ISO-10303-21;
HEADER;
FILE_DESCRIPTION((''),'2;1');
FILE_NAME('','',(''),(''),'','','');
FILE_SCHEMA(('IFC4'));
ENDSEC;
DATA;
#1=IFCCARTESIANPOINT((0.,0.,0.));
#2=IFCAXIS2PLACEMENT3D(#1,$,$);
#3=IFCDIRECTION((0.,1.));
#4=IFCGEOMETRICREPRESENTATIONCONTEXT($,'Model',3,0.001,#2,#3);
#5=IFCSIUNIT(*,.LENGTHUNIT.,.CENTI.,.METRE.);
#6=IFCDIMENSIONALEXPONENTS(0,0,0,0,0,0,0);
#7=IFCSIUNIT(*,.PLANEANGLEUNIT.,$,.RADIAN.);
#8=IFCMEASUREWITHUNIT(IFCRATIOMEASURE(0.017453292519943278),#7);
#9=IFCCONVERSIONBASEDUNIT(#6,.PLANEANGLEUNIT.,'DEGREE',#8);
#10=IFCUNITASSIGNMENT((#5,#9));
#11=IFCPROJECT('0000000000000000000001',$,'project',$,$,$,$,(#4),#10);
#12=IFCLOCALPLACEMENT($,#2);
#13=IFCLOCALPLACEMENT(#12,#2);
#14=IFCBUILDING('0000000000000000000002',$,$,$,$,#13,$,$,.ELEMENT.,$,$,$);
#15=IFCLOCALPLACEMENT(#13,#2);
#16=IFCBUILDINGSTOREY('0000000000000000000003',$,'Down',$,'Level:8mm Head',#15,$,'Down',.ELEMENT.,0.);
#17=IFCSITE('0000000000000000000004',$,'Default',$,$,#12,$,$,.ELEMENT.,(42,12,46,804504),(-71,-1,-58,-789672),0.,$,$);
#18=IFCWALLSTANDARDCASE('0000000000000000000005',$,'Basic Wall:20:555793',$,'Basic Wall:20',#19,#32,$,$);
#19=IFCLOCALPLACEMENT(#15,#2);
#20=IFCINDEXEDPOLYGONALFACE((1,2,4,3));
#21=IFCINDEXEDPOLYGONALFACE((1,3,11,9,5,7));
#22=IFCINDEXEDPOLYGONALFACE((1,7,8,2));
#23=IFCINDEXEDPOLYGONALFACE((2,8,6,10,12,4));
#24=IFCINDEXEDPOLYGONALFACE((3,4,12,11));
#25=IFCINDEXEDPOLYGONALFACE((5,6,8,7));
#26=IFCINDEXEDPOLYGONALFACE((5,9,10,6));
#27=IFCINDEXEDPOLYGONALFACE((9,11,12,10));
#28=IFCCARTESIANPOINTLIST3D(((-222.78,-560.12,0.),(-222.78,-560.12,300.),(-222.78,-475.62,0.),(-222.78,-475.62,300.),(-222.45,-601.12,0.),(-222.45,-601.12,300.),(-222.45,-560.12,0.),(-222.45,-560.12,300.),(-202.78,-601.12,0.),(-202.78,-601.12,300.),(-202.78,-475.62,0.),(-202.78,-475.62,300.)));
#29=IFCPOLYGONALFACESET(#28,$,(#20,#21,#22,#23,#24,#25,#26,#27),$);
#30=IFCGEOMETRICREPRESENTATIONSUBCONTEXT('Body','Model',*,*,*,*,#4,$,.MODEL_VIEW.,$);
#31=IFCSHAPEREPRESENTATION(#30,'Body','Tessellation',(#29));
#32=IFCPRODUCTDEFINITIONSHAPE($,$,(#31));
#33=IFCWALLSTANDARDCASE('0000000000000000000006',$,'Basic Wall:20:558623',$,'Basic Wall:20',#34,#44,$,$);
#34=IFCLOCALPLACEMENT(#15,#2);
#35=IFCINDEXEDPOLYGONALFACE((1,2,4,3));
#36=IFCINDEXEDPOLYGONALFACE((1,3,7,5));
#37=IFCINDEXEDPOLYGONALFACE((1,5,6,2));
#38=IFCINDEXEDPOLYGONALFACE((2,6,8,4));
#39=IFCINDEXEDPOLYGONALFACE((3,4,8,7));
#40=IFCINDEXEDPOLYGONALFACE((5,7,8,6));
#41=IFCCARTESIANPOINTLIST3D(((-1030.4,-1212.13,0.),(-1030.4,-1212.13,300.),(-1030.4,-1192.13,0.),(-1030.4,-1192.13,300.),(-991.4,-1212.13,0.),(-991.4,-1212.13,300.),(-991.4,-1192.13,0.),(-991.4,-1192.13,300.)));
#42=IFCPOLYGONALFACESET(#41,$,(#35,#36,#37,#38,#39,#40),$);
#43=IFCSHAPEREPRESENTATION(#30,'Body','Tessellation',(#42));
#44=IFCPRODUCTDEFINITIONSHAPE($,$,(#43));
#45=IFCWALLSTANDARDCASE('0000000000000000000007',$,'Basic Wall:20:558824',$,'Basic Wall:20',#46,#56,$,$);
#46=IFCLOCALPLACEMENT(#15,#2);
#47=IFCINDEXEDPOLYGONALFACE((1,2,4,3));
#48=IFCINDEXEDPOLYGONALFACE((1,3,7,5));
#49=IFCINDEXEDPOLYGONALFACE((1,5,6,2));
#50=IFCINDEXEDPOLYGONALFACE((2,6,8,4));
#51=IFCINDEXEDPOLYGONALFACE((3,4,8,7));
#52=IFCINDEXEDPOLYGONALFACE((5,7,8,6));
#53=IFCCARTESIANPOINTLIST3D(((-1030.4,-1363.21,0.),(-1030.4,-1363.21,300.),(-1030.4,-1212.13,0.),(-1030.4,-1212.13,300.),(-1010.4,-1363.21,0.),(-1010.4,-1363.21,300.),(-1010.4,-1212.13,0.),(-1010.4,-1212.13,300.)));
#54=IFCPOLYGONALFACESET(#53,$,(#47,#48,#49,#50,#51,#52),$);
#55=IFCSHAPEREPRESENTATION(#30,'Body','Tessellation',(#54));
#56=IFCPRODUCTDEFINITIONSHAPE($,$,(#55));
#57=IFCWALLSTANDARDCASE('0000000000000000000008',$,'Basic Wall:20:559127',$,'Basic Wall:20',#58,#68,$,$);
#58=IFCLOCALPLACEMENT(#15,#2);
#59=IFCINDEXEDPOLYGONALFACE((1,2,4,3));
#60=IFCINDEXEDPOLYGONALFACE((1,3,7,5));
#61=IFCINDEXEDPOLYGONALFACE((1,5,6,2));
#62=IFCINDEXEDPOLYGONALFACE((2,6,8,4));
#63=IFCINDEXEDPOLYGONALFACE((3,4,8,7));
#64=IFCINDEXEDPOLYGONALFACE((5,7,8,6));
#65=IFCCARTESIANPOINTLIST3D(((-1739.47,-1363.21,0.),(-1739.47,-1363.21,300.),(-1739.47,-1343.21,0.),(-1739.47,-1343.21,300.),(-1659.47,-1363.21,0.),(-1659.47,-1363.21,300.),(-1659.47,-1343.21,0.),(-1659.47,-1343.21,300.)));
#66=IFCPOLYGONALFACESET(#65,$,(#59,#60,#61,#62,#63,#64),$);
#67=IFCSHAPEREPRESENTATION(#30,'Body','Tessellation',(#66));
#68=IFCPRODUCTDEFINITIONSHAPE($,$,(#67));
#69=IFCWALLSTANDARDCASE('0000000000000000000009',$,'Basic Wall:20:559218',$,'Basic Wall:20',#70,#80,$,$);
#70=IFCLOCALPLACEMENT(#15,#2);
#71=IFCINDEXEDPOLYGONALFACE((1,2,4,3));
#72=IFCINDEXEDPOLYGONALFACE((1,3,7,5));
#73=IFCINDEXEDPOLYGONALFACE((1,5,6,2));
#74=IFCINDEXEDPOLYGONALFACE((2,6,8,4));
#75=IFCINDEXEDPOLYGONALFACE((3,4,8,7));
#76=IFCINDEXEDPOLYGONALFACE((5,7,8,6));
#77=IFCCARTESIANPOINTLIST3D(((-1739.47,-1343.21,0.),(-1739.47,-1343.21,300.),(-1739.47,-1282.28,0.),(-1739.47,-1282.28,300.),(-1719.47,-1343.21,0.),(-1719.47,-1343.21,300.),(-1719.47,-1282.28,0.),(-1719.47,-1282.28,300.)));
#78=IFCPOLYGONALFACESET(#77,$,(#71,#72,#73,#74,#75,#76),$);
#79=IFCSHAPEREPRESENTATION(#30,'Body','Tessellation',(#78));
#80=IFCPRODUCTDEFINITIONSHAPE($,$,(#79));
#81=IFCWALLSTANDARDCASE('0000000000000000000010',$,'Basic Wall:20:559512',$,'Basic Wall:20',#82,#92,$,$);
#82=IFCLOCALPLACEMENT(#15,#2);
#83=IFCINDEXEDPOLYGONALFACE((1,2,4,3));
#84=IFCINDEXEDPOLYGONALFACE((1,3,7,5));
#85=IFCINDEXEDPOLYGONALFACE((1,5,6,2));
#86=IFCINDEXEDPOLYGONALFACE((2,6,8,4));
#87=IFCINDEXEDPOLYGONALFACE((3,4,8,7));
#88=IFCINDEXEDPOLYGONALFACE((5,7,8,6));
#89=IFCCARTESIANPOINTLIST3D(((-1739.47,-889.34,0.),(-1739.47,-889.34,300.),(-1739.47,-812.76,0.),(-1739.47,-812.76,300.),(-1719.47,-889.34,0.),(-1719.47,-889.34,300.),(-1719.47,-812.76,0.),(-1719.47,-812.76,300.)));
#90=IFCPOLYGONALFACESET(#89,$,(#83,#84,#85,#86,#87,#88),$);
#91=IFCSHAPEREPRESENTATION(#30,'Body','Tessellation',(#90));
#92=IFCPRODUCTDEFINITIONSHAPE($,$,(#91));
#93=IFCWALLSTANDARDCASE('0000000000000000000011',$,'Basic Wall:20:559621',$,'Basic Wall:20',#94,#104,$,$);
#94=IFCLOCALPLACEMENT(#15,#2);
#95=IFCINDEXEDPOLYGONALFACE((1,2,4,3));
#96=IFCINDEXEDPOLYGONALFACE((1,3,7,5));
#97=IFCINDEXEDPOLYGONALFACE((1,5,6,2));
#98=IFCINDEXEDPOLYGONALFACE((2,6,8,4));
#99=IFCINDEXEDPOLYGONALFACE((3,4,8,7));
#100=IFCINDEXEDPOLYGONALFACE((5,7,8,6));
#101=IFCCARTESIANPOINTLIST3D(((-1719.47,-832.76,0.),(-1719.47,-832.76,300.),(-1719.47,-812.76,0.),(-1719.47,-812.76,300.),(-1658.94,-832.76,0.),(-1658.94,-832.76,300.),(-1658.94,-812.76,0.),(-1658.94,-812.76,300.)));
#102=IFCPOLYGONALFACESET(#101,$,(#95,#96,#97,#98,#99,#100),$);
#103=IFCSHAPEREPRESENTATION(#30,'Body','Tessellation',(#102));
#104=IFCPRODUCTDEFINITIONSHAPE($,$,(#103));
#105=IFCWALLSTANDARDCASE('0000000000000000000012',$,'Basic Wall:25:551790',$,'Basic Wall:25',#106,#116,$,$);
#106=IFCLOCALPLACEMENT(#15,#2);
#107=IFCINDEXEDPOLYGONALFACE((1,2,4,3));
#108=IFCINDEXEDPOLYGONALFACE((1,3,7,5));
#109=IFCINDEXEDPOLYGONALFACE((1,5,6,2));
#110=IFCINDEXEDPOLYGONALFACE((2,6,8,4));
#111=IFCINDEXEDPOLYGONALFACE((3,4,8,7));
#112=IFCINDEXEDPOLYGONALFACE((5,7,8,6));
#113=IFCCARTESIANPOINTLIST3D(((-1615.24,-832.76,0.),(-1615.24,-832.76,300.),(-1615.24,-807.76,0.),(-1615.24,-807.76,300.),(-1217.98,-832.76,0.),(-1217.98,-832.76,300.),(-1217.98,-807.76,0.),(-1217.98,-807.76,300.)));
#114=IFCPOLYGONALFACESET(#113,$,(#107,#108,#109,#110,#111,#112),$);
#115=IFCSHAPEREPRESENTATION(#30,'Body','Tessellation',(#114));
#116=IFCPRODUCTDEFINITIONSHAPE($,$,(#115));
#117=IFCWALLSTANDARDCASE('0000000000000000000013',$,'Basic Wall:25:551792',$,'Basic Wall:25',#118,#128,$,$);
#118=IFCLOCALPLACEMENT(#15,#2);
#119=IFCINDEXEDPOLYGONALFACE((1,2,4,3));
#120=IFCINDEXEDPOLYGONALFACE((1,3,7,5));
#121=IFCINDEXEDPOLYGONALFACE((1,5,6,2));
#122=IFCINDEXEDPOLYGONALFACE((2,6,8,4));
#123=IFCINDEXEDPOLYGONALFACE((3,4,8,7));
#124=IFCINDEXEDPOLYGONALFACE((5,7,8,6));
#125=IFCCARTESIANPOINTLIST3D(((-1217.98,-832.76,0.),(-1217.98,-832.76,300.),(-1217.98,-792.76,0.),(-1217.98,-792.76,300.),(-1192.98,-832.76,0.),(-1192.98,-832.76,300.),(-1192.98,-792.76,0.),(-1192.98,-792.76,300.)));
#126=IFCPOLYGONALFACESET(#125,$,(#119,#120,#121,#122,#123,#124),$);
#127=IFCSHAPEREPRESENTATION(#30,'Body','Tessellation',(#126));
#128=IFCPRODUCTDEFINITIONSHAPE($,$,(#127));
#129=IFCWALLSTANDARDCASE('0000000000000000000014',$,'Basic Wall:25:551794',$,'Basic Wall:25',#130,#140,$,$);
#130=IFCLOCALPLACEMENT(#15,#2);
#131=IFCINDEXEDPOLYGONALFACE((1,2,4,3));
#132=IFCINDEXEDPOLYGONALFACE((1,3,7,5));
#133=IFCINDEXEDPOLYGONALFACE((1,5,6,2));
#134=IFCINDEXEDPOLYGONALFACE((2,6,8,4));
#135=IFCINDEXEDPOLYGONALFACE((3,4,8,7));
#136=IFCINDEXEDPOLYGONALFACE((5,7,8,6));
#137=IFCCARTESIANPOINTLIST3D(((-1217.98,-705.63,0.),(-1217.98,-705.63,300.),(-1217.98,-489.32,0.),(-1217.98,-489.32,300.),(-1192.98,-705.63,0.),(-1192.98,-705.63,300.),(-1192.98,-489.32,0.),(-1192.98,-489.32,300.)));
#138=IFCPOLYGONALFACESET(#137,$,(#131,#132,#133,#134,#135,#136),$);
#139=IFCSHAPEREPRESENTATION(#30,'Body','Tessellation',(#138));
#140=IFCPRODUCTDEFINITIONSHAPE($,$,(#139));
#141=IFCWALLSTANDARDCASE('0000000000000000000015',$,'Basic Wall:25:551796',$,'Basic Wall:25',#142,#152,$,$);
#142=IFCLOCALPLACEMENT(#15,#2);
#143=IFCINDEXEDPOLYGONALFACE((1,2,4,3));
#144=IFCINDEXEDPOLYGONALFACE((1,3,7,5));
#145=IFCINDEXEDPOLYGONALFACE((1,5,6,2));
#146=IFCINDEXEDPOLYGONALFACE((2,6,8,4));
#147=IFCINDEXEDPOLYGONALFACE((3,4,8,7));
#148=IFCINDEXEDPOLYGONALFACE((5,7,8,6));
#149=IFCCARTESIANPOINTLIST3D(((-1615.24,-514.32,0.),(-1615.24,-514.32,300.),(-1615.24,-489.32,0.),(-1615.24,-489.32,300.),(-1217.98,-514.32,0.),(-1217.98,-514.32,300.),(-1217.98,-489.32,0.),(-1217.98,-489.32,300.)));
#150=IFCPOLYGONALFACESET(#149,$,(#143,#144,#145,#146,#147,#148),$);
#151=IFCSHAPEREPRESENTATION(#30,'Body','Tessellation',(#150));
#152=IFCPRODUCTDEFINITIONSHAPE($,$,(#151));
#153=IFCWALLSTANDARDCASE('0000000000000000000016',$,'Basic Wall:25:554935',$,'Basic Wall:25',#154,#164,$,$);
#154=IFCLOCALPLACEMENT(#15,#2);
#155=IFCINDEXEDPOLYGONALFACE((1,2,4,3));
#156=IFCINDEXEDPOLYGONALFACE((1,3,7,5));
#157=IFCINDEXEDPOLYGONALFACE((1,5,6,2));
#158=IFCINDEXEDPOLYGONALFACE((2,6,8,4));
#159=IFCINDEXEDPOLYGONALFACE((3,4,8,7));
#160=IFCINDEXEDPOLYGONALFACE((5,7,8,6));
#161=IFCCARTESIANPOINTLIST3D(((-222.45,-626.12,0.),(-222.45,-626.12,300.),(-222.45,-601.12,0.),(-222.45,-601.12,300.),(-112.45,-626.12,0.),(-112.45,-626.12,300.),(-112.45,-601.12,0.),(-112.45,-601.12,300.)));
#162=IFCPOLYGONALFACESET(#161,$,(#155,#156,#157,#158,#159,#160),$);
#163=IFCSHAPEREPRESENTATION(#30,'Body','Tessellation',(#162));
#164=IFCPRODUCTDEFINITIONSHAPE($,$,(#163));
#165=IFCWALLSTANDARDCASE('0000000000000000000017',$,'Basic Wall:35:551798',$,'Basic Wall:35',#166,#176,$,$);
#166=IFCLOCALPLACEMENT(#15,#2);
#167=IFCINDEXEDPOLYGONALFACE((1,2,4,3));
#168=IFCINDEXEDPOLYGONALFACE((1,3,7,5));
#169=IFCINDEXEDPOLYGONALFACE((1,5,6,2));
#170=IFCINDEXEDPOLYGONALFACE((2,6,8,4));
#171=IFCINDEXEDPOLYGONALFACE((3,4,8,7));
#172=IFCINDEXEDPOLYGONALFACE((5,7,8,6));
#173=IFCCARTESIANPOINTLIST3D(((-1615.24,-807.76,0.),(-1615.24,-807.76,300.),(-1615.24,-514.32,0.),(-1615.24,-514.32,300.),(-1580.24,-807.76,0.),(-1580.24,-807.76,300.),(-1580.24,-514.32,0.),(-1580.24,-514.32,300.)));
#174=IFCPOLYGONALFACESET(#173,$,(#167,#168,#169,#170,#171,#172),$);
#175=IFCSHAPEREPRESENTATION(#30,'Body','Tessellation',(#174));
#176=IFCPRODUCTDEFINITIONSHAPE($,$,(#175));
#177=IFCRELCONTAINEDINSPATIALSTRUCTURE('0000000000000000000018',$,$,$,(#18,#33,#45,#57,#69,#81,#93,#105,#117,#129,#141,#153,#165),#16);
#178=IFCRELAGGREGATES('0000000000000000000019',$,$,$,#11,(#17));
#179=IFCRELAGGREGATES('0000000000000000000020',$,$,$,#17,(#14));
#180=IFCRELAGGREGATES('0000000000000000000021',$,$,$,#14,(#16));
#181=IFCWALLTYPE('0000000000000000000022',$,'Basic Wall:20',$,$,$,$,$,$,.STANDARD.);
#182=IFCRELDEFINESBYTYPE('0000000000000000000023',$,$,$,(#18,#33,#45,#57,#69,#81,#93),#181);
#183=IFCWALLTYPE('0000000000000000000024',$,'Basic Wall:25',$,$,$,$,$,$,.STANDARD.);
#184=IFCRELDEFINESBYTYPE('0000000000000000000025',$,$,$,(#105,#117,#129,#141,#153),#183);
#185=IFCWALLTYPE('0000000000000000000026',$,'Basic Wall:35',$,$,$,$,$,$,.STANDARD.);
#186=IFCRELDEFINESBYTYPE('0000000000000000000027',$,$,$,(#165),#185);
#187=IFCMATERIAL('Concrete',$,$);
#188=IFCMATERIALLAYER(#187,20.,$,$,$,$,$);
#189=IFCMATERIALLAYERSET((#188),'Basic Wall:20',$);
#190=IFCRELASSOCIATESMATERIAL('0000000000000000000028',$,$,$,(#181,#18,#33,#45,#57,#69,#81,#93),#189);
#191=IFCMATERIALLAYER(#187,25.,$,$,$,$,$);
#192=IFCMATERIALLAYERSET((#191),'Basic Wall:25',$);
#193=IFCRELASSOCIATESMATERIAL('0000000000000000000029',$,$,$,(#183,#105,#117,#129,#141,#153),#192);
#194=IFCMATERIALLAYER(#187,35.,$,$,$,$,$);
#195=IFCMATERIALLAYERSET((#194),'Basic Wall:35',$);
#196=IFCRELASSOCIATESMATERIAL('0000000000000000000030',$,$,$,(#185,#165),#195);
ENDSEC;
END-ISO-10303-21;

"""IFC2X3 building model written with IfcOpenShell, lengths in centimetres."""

from ifc_helpers import new_model, entity, si_unit, converted_unit, direction, frame, frame_2d, origin, place, context, subcontext, project, spatial, polyline, rectangle, extrude, clip, bounded_halfspace, material, layer, layer_set, layer_usage, type_object, element, save


model = new_model("IFC2X3")

# Units and contexts
model_context = context("Model", 3, precision=0.001, world=origin(), true_north=direction((0.0, 1.0)))
body_context = subcontext(model_context, "Body", "Model", "MODEL_VIEW")
ifc_project = project(units=[si_unit("LENGTHUNIT", "METRE", prefix="CENTI"), converted_unit("PLANEANGLEUNIT", "DEGREE", entity("IfcRatioMeasure", 0.017453292519943278), si_unit("PLANEANGLEUNIT", "RADIAN"), dimensions=[0, 0, 0, 0, 0, 0, 0])], contexts=[model_context])

# Site, building, storey
site_placement = place(None, origin())
site = spatial("IfcSite", under=ifc_project, at=site_placement, Name="Default", CompositionType="ELEMENT", RefLatitude=(42, 12, 46, 804504), RefLongitude=(-71, -1, -58, -789672), RefElevation=0.0)
building_placement = place(site_placement, origin())
building = spatial("IfcBuilding", under=site, at=building_placement, CompositionType="ELEMENT")
storey_placement = place(building_placement, origin())
storey = spatial("IfcBuildingStorey", under=building, at=storey_placement, Name="Down", ObjectType="Level:8mm Head", LongName="Down", CompositionType="ELEMENT", Elevation=0.0)

# Shared definitions
ifc_material = material(Name="Concrete")

# Walls
ifc_layer_1 = layer(ifc_material, 20.0)
ifc_layer_set_1 = layer_set([ifc_layer_1], Name="Basic Wall:20")
wall_type_1 = type_object("IfcWallType", Name="Basic Wall:20", PredefinedType="STANDARD", material=ifc_layer_set_1)
ifc_layer_usage_1 = layer_usage(ifc_layer_set_1, "AXIS2", "NEGATIVE", 10.0)
wall_1_placement = place(storey_placement, frame((-212.78, -475.62, 0.0), z_axis=(0.0, 0.0, 1.0), x_axis=(0.0, -1.0, 0.0)))
element("IfcWallStandardCase", 1, at=wall_1_placement, inside=storey, type_object=wall_type_1, material=ifc_layer_usage_1, Name="Basic Wall:20:555793", ObjectType="Basic Wall:20", context=body_context, shape_type="Clipping", body=[
    clip(clip(extrude(rectangle(XDim=125.5, YDim=20.0, at=frame_2d((62.75, 0.0), x_axis=(-1.0, 0.0))), origin(), (0.0, 0.0, 1.0), 300.0), bounded_halfspace(frame((84.5, -9.67, 300.0), z_axis=(0.0, 1.0, 0.0), x_axis=(-1.0, 0.0, 0.0)), True, frame((84.5, -9.67, 300.0), z_axis=(0.0, 1.0, 0.0), x_axis=(-1.0, 0.0, 0.0)), polyline([(0.0, 0.0), (-41.0, 0.0), (-41.0, -300.0), (0.0, -300.0), (0.0, 0.0)]))), bounded_halfspace(frame((84.5, -9.67, 0.0), z_axis=(-1.0, 0.0, 0.0), x_axis=(0.0, -1.0, 0.0)), True, frame((84.5, -9.67, 0.0), z_axis=(-1.0, 0.0, 0.0), x_axis=(0.0, -1.0, 0.0)), polyline([(0.0, 0.0), (0.33, 0.0), (0.33, 300.0), (0.0, 300.0), (0.0, 0.0)]))),
])
ifc_layer_usage_2 = layer_usage(ifc_layer_set_1, "AXIS2", "POSITIVE", -10.0)
wall_2_placement = place(storey_placement, frame((-991.4, -1202.13, 0.0), z_axis=(0.0, 0.0, 1.0), x_axis=(-1.0, 0.0, 0.0)))
element("IfcWallStandardCase", 2, at=wall_2_placement, inside=storey, type_object=wall_type_1, material=ifc_layer_usage_2, Name="Basic Wall:20:558623", ObjectType="Basic Wall:20", context=body_context, shape_type="SweptSolid", body=[
    extrude(rectangle(XDim=39.0, YDim=20.0, at=frame_2d((19.5, 0.0), x_axis=(-1.0, 0.0))), origin(), (0.0, 0.0, 1.0), 300.0),
])
ifc_layer_usage_3 = layer_usage(ifc_layer_set_1, "AXIS2", "POSITIVE", -10.0)
wall_3_placement = place(storey_placement, frame((-1020.4, -1212.13, 0.0), z_axis=(0.0, 0.0, 1.0), x_axis=(0.0, -1.0, 0.0)))
element("IfcWallStandardCase", 3, at=wall_3_placement, inside=storey, type_object=wall_type_1, material=ifc_layer_usage_3, Name="Basic Wall:20:558824", ObjectType="Basic Wall:20", context=body_context, shape_type="SweptSolid", body=[
    extrude(rectangle(XDim=151.08, YDim=20.0, at=frame_2d((75.54, 0.0), x_axis=(-1.0, 0.0))), origin(), (0.0, 0.0, 1.0), 300.0),
])
ifc_layer_usage_4 = layer_usage(ifc_layer_set_1, "AXIS2", "NEGATIVE", 10.0)
wall_4_placement = place(storey_placement, frame((-1659.47, -1353.21, 0.0), z_axis=(0.0, 0.0, 1.0), x_axis=(-1.0, 0.0, 0.0)))
element("IfcWallStandardCase", 4, at=wall_4_placement, inside=storey, type_object=wall_type_1, material=ifc_layer_usage_4, Name="Basic Wall:20:559127", ObjectType="Basic Wall:20", context=body_context, shape_type="SweptSolid", body=[
    extrude(rectangle(XDim=80.0, YDim=20.0, at=frame_2d((40.0, 0.0), x_axis=(-1.0, 0.0))), origin(), (0.0, 0.0, 1.0), 300.0),
])
ifc_layer_usage_5 = layer_usage(ifc_layer_set_1, "AXIS2", "NEGATIVE", 10.0)
wall_5_placement = place(storey_placement, frame((-1729.47, -1343.21, 0.0), z_axis=(0.0, 0.0, 1.0), x_axis=(0.0, 1.0, 0.0)))
element("IfcWallStandardCase", 5, at=wall_5_placement, inside=storey, type_object=wall_type_1, material=ifc_layer_usage_5, Name="Basic Wall:20:559218", ObjectType="Basic Wall:20", context=body_context, shape_type="SweptSolid", body=[
    extrude(rectangle(XDim=60.93, YDim=20.0, at=frame_2d((30.47, 0.0), x_axis=(-1.0, 0.0))), origin(), (0.0, 0.0, 1.0), 300.0),
])
ifc_layer_usage_6 = layer_usage(ifc_layer_set_1, "AXIS2", "NEGATIVE", 10.0)
wall_6_placement = place(storey_placement, frame((-1729.47, -889.34, 0.0), z_axis=(0.0, 0.0, 1.0), x_axis=(0.0, 1.0, 0.0)))
element("IfcWallStandardCase", 6, at=wall_6_placement, inside=storey, type_object=wall_type_1, material=ifc_layer_usage_6, Name="Basic Wall:20:559512", ObjectType="Basic Wall:20", context=body_context, shape_type="SweptSolid", body=[
    extrude(rectangle(XDim=76.59, YDim=20.0, at=frame_2d((38.29, 0.0), x_axis=(-1.0, 0.0))), origin(), (0.0, 0.0, 1.0), 300.0),
])
ifc_layer_usage_7 = layer_usage(ifc_layer_set_1, "AXIS2", "NEGATIVE", 10.0)
wall_7_placement = place(storey_placement, frame((-1719.47, -822.76, 0.0)))
element("IfcWallStandardCase", 7, at=wall_7_placement, inside=storey, type_object=wall_type_1, material=ifc_layer_usage_7, Name="Basic Wall:20:559621", ObjectType="Basic Wall:20", context=body_context, shape_type="SweptSolid", body=[
    extrude(rectangle(XDim=60.53, YDim=20.0, at=frame_2d((30.27, 0.0), x_axis=(-1.0, 0.0))), origin(), (0.0, 0.0, 1.0), 300.0),
])
ifc_layer_2 = layer(ifc_material, 25.0)
ifc_layer_set_2 = layer_set([ifc_layer_2], Name="Basic Wall:25")
ifc_layer_usage_8 = layer_usage(ifc_layer_set_2, "AXIS2", "NEGATIVE", 12.5)
wall_type_2 = type_object("IfcWallType", Name="Basic Wall:25", PredefinedType="STANDARD", material=ifc_layer_set_2)
wall_8_placement = place(storey_placement, frame((-1217.98, -820.26, 0.0), z_axis=(0.0, 0.0, 1.0), x_axis=(-1.0, 0.0, 0.0)))
element("IfcWallStandardCase", 8, at=wall_8_placement, inside=storey, type_object=wall_type_2, material=ifc_layer_usage_8, Name="Basic Wall:25:551790", ObjectType="Basic Wall:25", context=body_context, shape_type="SweptSolid", body=[
    extrude(rectangle(XDim=397.26, YDim=25.0, at=frame_2d((198.63, 0.0), x_axis=(-1.0, 0.0))), origin(), (0.0, 0.0, 1.0), 300.0),
])
ifc_layer_usage_9 = layer_usage(ifc_layer_set_2, "AXIS2", "POSITIVE", -12.5)
wall_9_placement = place(storey_placement, frame((-1205.48, -832.76, 0.0), z_axis=(0.0, 0.0, 1.0), x_axis=(0.0, 1.0, 0.0)))
element("IfcWallStandardCase", 9, at=wall_9_placement, inside=storey, type_object=wall_type_2, material=ifc_layer_usage_9, Name="Basic Wall:25:551792", ObjectType="Basic Wall:25", context=body_context, shape_type="SweptSolid", body=[
    extrude(rectangle(XDim=40.0, YDim=25.0, at=frame_2d((20.0, 0.0), x_axis=(-1.0, 0.0))), origin(), (0.0, 0.0, 1.0), 300.0),
])
ifc_layer_usage_10 = layer_usage(ifc_layer_set_2, "AXIS2", "POSITIVE", -12.5)
wall_10_placement = place(storey_placement, frame((-1205.48, -705.63, 0.0), z_axis=(0.0, 0.0, 1.0), x_axis=(0.0, 1.0, 0.0)))
element("IfcWallStandardCase", 10, at=wall_10_placement, inside=storey, type_object=wall_type_2, material=ifc_layer_usage_10, Name="Basic Wall:25:551794", ObjectType="Basic Wall:25", context=body_context, shape_type="SweptSolid", body=[
    extrude(rectangle(XDim=216.31, YDim=25.0, at=frame_2d((108.15, 0.0), x_axis=(-1.0, 0.0))), origin(), (0.0, 0.0, 1.0), 300.0),
])
ifc_layer_usage_11 = layer_usage(ifc_layer_set_2, "AXIS2", "POSITIVE", -12.5)
wall_11_placement = place(storey_placement, frame((-1217.98, -501.82, 0.0), z_axis=(0.0, 0.0, 1.0), x_axis=(-1.0, 0.0, 0.0)))
element("IfcWallStandardCase", 11, at=wall_11_placement, inside=storey, type_object=wall_type_2, material=ifc_layer_usage_11, Name="Basic Wall:25:551796", ObjectType="Basic Wall:25", context=body_context, shape_type="SweptSolid", body=[
    extrude(rectangle(XDim=397.26, YDim=25.0, at=frame_2d((198.63, 0.0), x_axis=(-1.0, 0.0))), origin(), (0.0, 0.0, 1.0), 300.0),
])
ifc_layer_usage_12 = layer_usage(ifc_layer_set_2, "AXIS2", "POSITIVE", -12.5)
wall_12_placement = place(storey_placement, frame((-222.45, -613.62, 0.0)))
element("IfcWallStandardCase", 12, at=wall_12_placement, inside=storey, type_object=wall_type_2, material=ifc_layer_usage_12, Name="Basic Wall:25:554935", ObjectType="Basic Wall:25", context=body_context, shape_type="SweptSolid", body=[
    extrude(rectangle(XDim=110.0, YDim=25.0, at=frame_2d((55.0, 0.0), x_axis=(-1.0, 0.0))), origin(), (0.0, 0.0, 1.0), 300.0),
])
ifc_layer_3 = layer(ifc_material, 35.0)
ifc_layer_set_3 = layer_set([ifc_layer_3], Name="Basic Wall:35")
ifc_layer_usage_13 = layer_usage(ifc_layer_set_3, "AXIS2", "NEGATIVE", 17.5)
wall_type_3 = type_object("IfcWallType", Name="Basic Wall:35", PredefinedType="STANDARD", material=ifc_layer_set_3)
wall_13_placement = place(storey_placement, frame((-1597.74, -514.32, 0.0), z_axis=(0.0, 0.0, 1.0), x_axis=(0.0, -1.0, 0.0)))
element("IfcWallStandardCase", 13, at=wall_13_placement, inside=storey, type_object=wall_type_3, material=ifc_layer_usage_13, Name="Basic Wall:35:551798", ObjectType="Basic Wall:35", context=body_context, shape_type="SweptSolid", body=[
    extrude(rectangle(XDim=293.44, YDim=35.0, at=frame_2d((146.72, 0.0), x_axis=(-1.0, 0.0))), origin(), (0.0, 0.0, 1.0), 300.0),
])

save(model, "model.ifc")
